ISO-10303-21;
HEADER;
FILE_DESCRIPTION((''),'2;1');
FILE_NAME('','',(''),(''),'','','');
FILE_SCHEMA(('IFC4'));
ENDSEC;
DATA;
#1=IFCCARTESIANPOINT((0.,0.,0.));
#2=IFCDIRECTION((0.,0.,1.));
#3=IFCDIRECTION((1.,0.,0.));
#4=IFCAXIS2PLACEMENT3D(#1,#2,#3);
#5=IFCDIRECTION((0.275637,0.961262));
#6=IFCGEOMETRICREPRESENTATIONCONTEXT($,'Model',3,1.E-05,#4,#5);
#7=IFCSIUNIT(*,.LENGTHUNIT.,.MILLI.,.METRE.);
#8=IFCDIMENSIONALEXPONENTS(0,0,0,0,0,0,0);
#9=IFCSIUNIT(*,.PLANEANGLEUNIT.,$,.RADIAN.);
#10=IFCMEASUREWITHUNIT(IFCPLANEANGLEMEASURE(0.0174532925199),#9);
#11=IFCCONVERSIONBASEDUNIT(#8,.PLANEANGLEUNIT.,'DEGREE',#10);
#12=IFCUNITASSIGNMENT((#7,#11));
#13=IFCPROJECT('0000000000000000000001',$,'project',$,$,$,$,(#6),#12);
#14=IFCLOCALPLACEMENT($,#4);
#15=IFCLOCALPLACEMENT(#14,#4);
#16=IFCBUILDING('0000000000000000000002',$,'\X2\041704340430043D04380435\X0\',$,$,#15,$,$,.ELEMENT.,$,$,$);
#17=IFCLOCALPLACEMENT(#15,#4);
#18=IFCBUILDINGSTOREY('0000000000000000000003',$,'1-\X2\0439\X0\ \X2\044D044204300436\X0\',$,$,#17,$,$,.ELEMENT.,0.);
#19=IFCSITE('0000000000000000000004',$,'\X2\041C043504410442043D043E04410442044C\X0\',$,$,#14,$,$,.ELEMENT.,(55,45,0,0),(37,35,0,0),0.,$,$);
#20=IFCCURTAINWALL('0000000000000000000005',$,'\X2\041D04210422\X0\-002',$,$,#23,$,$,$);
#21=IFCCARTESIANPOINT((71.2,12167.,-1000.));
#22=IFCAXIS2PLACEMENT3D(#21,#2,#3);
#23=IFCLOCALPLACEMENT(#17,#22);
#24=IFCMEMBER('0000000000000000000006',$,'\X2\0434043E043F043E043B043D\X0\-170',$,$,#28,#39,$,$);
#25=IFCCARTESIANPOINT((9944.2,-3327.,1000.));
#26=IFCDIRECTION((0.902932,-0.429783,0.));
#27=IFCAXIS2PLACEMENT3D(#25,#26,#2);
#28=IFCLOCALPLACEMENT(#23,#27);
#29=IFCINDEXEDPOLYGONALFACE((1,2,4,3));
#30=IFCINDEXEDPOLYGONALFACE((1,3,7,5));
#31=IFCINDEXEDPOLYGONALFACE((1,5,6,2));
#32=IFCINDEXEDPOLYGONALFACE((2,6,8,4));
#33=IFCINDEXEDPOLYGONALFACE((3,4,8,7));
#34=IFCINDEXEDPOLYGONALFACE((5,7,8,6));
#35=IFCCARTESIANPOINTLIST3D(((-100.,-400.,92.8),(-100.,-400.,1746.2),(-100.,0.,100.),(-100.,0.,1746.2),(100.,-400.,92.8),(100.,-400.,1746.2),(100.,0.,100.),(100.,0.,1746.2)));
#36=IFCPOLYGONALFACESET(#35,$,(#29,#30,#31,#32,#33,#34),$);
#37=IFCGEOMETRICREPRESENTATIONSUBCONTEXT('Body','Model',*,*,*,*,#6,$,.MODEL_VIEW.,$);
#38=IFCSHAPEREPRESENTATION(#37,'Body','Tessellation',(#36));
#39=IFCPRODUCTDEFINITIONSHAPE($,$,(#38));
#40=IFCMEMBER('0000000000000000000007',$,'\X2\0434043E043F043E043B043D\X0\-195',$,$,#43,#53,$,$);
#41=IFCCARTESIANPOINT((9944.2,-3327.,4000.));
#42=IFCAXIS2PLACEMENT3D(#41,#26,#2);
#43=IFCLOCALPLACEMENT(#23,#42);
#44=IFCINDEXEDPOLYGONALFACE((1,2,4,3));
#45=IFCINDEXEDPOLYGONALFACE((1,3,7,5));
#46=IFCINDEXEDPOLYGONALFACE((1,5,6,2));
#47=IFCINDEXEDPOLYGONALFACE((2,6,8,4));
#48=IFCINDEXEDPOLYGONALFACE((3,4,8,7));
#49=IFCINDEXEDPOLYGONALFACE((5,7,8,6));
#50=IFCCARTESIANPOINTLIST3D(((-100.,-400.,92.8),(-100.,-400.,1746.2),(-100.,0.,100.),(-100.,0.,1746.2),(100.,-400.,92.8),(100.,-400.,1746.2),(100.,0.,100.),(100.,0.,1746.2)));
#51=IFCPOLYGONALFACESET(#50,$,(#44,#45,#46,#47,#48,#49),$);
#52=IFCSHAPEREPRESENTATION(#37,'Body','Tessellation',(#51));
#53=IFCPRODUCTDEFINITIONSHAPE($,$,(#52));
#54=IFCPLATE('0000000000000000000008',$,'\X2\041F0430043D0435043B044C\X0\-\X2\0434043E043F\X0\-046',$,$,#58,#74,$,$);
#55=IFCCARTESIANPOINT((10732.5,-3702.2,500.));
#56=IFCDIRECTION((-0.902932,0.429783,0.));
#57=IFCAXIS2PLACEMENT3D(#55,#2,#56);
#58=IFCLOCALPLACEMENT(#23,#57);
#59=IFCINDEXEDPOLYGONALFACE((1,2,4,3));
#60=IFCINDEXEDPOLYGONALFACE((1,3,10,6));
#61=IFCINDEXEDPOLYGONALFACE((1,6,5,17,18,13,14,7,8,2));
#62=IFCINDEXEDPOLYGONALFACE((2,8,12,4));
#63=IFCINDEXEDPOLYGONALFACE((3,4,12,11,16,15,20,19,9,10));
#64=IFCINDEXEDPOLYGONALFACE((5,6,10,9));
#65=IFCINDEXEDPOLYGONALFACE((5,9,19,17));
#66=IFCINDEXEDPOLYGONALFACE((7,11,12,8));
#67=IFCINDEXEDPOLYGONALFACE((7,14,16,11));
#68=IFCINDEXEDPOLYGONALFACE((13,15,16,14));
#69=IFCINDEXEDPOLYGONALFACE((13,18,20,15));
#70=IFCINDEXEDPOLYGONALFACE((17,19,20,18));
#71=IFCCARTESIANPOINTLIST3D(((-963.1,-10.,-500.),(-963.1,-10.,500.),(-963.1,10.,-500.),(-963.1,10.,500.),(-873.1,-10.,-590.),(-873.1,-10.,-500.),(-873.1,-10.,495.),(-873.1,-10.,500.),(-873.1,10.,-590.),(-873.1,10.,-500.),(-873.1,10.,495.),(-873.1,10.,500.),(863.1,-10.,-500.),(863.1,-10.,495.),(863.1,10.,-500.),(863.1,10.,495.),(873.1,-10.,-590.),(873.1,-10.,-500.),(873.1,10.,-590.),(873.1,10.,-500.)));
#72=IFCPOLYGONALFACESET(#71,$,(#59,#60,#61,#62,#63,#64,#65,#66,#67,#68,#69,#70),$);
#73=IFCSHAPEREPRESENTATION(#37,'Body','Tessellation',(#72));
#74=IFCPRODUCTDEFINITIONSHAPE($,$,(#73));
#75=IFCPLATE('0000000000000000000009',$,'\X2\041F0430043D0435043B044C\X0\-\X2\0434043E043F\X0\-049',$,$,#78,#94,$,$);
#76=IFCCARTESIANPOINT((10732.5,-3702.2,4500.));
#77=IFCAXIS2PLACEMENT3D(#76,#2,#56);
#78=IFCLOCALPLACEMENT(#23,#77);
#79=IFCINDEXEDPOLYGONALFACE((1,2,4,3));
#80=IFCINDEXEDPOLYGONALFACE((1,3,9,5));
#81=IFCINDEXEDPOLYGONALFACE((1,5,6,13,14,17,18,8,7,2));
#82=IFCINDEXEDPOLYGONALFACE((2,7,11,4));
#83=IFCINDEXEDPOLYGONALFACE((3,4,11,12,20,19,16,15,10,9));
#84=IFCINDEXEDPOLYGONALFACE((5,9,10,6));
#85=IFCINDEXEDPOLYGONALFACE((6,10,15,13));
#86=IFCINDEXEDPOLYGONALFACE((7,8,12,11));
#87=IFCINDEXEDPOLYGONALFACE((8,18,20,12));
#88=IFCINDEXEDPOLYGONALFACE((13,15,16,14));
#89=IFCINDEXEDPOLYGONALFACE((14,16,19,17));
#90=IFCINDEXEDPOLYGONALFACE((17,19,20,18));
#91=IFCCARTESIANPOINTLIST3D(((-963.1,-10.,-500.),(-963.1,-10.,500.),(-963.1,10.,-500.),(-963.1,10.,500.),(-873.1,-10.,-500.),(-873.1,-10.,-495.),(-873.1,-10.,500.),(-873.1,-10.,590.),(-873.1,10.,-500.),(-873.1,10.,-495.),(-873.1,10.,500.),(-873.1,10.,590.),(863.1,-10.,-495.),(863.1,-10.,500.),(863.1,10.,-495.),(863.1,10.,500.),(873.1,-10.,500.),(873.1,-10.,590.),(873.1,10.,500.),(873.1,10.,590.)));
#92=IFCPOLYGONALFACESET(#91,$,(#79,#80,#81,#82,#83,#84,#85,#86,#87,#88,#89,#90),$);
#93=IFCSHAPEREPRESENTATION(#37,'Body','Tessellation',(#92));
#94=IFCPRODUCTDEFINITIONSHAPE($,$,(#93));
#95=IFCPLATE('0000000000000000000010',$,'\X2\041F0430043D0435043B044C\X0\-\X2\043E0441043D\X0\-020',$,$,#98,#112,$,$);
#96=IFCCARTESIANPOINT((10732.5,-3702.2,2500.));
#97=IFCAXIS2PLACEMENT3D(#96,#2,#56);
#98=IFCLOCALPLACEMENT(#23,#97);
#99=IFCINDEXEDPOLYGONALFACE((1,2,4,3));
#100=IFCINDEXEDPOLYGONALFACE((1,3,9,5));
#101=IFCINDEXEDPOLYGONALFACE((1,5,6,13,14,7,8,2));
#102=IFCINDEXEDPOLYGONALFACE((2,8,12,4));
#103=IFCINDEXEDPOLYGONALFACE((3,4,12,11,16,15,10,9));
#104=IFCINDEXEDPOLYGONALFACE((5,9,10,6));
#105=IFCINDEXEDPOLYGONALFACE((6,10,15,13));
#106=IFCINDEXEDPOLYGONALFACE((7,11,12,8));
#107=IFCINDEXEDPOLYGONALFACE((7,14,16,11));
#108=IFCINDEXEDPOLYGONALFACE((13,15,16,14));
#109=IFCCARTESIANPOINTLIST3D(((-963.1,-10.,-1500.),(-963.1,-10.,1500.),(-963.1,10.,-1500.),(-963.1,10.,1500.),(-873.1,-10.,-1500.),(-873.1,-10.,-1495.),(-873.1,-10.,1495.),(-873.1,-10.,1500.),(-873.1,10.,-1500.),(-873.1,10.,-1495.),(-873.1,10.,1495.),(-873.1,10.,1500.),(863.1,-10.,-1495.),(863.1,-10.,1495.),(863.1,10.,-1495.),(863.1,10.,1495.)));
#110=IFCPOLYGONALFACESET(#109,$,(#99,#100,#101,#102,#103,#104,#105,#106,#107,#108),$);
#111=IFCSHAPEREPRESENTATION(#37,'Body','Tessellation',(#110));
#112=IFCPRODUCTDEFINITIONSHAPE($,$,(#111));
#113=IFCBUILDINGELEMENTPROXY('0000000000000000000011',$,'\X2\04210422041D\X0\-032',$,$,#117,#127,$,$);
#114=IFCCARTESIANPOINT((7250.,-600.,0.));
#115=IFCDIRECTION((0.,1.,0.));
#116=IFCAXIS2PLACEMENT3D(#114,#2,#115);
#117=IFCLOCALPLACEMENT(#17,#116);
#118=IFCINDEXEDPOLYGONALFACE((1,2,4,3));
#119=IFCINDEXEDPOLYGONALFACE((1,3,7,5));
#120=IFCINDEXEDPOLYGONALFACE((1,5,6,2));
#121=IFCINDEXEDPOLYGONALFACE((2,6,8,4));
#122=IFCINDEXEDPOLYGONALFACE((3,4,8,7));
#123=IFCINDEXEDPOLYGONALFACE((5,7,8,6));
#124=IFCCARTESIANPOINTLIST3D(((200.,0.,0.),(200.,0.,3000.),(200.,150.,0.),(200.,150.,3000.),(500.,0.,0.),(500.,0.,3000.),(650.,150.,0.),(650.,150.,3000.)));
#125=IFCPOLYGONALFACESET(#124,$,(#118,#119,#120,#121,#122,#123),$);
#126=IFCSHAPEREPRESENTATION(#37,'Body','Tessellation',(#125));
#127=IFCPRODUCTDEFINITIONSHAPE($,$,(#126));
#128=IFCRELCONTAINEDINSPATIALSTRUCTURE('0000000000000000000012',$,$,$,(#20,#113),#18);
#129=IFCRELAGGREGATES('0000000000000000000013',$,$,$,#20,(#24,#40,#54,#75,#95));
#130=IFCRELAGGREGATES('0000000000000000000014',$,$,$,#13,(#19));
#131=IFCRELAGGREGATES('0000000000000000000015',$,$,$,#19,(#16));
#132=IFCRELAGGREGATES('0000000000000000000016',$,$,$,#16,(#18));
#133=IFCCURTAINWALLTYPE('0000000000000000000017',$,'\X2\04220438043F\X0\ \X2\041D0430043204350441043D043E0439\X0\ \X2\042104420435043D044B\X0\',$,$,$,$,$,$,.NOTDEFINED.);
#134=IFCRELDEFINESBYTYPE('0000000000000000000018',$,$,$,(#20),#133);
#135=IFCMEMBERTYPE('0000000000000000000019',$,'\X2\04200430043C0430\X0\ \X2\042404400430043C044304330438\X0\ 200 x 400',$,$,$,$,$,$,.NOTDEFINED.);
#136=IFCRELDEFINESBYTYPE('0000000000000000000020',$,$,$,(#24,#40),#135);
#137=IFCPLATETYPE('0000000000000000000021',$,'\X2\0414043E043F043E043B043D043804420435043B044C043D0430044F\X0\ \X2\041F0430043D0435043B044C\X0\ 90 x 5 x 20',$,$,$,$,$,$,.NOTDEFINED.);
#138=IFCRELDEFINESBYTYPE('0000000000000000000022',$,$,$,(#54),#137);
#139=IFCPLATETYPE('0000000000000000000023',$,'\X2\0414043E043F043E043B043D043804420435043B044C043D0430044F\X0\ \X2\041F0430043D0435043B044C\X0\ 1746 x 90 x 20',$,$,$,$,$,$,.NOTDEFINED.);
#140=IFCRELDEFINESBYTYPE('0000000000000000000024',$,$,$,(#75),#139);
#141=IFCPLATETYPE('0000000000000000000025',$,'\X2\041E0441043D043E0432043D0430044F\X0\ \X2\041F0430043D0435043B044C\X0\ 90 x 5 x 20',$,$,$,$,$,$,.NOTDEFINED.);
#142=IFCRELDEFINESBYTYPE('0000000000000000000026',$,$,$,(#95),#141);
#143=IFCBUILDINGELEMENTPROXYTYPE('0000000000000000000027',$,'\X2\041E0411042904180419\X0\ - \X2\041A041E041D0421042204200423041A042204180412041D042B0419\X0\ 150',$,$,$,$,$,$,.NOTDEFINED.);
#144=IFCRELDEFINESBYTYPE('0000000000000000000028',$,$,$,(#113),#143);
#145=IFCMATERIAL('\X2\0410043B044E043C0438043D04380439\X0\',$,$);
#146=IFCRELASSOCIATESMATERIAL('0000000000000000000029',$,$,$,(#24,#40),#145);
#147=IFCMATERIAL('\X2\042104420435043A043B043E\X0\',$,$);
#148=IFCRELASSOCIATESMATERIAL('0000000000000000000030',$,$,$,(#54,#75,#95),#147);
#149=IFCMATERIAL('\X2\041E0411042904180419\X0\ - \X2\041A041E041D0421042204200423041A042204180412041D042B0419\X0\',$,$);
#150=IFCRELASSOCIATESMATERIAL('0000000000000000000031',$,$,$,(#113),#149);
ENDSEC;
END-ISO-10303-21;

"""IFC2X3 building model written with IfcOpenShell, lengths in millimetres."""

from ifc_helpers import new_model, entity, si_unit, converted_unit, direction, frame, origin_with_axes, place, context, subcontext, project, spatial, polyline, outline, extrude, clip, halfspace, material, type_object, element, aggregate, save


model = new_model("IFC2X3")

# Units and contexts
model_context = context("Model", 3, precision=1e-05, world=origin_with_axes(), true_north=direction((0.275637, 0.961262)))
body_context = subcontext(model_context, "Body", "Model", "MODEL_VIEW")
ifc_project = project(units=[si_unit("LENGTHUNIT", "METRE", prefix="MILLI"), converted_unit("PLANEANGLEUNIT", "DEGREE", entity("IfcPlaneAngleMeasure", 0.0174532925199), si_unit("PLANEANGLEUNIT", "RADIAN"), dimensions=[0, 0, 0, 0, 0, 0, 0])], contexts=[model_context])

# Site, building, storey
site_placement = place(None, origin_with_axes())
site = spatial("IfcSite", under=ifc_project, at=site_placement, Name="Местность", CompositionType="ELEMENT", RefLatitude=(55, 45, 0, 0), RefLongitude=(37, 35, 0, 0), RefElevation=0.0)
building_placement = place(site_placement, origin_with_axes())
building = spatial("IfcBuilding", under=site, at=building_placement, Name="Здание", CompositionType="ELEMENT")
storey_placement = place(building_placement, origin_with_axes())
storey = spatial("IfcBuildingStorey", under=building, at=storey_placement, Name="1-й этаж", CompositionType="ELEMENT", Elevation=0.0)

# Shared definitions
ifc_material_1 = material(Name="ОБЩИЙ - КОНСТРУКТИВНЫЙ")

# Curtain wall, members, plates
curtain_wall_type = type_object("IfcCurtainWallType", Name="Тип Навесной Стены", PredefinedType="NOTDEFINED")
curtain_wall_placement = place(storey_placement, frame((71.2, 12167.0, -1000.0), z_axis=(0.0, 0.0, 1.0), x_axis=(1.0, 0.0, 0.0)))
curtain_wall = element("IfcCurtainWall", 1, at=curtain_wall_placement, inside=storey, type_object=curtain_wall_type, Name="НСТ-002")
ifc_material_2 = material(Name="Алюминий")
member_type_1 = type_object("IfcMemberType", Name="Рама Фрамуги 200 x 400", PredefinedType="NOTDEFINED")
member_1_placement = place(curtain_wall_placement, frame((9944.2, -3327.0, 1000.0), z_axis=(0.902932, -0.429783, 0.0), x_axis=(0.0, 0.0, 1.0)))
member_1 = element("IfcMember", 2, at=member_1_placement, type_object=member_type_1, material=ifc_material_2, Name="дополн-170", context=body_context, shape_type="Clipping", body=[
    clip(extrude(outline(polyline([(-400.0, -100.0), (0.0, -100.0), (0.0, 100.0), (-400.0, 100.0), (-400.0, -100.0)])), frame((0.0, 0.0, 92.8), z_axis=(0.0, 0.0, 1.0), x_axis=(0.0, 1.0, 0.0)), (0.0, 0.0, 1.0), 1653.3), halfspace(frame((0.0, -1.8, 100.0), z_axis=(0.0, -0.017986, 0.999838), x_axis=(0.0, -0.999838, -0.017986)), True)),
])
member_2_placement = place(curtain_wall_placement, frame((9944.2, -3327.0, 4000.0), z_axis=(0.902932, -0.429783, 0.0), x_axis=(0.0, 0.0, 1.0)))
member_2 = element("IfcMember", 3, at=member_2_placement, type_object=member_type_1, material=ifc_material_2, Name="дополн-195", context=body_context, shape_type="Clipping", body=[
    clip(extrude(outline(polyline([(-400.0, -100.0), (0.0, -100.0), (0.0, 100.0), (-400.0, 100.0), (-400.0, -100.0)])), frame((0.0, 0.0, 92.8), z_axis=(0.0, 0.0, 1.0), x_axis=(0.0, 1.0, 0.0)), (0.0, 0.0, 1.0), 1653.3), halfspace(frame((0.0, -1.8, 100.0), z_axis=(0.0, -0.017986, 0.999838), x_axis=(0.0, -0.999838, -0.017986)), True)),
])
ifc_material_3 = material(Name="Стекло")
plate_type_1 = type_object("IfcPlateType", Name="Дополнительная Панель 90 x 5 x 20", PredefinedType="NOTDEFINED")
plate_1_placement = place(curtain_wall_placement, frame((10732.5, -3702.2, 500.0), z_axis=(0.0, 0.0, 1.0), x_axis=(-0.902932, 0.429783, 0.0)))
plate_1 = element("IfcPlate", 4, at=plate_1_placement, type_object=plate_type_1, material=ifc_material_3, Name="Панель-доп-046", context=body_context, shape_type="SweptSolid", body=[
    extrude(outline(polyline([(-963.1, -500.0), (-873.1, -500.0), (-873.1, -495.0), (863.1, -495.0), (863.1, 500.0), (873.1, 500.0), (873.1, 590.0), (-873.1, 590.0), (-873.1, 500.0), (-963.1, 500.0), (-963.1, -500.0)])), frame((0.0, -10.0, 0.0), z_axis=(0.0, 1.0, 0.0), x_axis=(1.0, 0.0, 0.0)), (0.0, 0.0, 1.0), 20.0),
])
plate_type_2 = type_object("IfcPlateType", Name="Дополнительная Панель 1746 x 90 x 20", PredefinedType="NOTDEFINED")
plate_2_placement = place(curtain_wall_placement, frame((10732.5, -3702.2, 4500.0), z_axis=(0.0, 0.0, 1.0), x_axis=(-0.902932, 0.429783, 0.0)))
plate_2 = element("IfcPlate", 5, at=plate_2_placement, type_object=plate_type_2, material=ifc_material_3, Name="Панель-доп-049", context=body_context, shape_type="SweptSolid", body=[
    extrude(outline(polyline([(-873.1, -590.0), (873.1, -590.0), (873.1, -500.0), (863.1, -500.0), (863.1, 495.0), (-873.1, 495.0), (-873.1, 500.0), (-963.1, 500.0), (-963.1, -500.0), (-873.1, -500.0), (-873.1, -590.0)])), frame((0.0, -10.0, 0.0), z_axis=(0.0, 1.0, 0.0), x_axis=(1.0, 0.0, 0.0)), (0.0, 0.0, 1.0), 20.0),
])
plate_type_3 = type_object("IfcPlateType", Name="Основная Панель 90 x 5 x 20", PredefinedType="NOTDEFINED")
plate_3_placement = place(curtain_wall_placement, frame((10732.5, -3702.2, 2500.0), z_axis=(0.0, 0.0, 1.0), x_axis=(-0.902932, 0.429783, 0.0)))
plate_3 = element("IfcPlate", 6, at=plate_3_placement, type_object=plate_type_3, material=ifc_material_3, Name="Панель-осн-020", context=body_context, shape_type="SweptSolid", body=[
    extrude(outline(polyline([(-963.1, -1500.0), (-873.1, -1500.0), (-873.1, -1495.0), (863.1, -1495.0), (863.1, 1495.0), (-873.1, 1495.0), (-873.1, 1500.0), (-963.1, 1500.0), (-963.1, -1500.0)])), frame((0.0, -10.0, 0.0), z_axis=(0.0, 1.0, 0.0), x_axis=(1.0, 0.0, 0.0)), (0.0, 0.0, 1.0), 20.0),
])
aggregate(curtain_wall, [member_1, member_2, plate_1, plate_2, plate_3])

# Building element proxy
building_element_proxy_type_1 = type_object("IfcBuildingElementProxyType", Name="ОБЩИЙ - КОНСТРУКТИВНЫЙ 150", PredefinedType="NOTDEFINED")
proxy_1_placement = place(storey_placement, frame((7250.0, -600.0, 0.0), z_axis=(0.0, 0.0, 1.0), x_axis=(0.0, 1.0, 0.0)))
element("IfcBuildingElementProxy", 7, at=proxy_1_placement, inside=storey, type_object=building_element_proxy_type_1, material=ifc_material_1, Name="СТН-032", context=body_context, shape_type="SweptSolid", body=[
    extrude(outline(polyline([(200.0, 0.0), (500.0, 0.0), (650.0, 150.0), (200.0, 150.0), (200.0, 0.0)])), origin_with_axes(), (0.0, 0.0, 1.0), 3000.0),
])

save(model, "model.ifc")
